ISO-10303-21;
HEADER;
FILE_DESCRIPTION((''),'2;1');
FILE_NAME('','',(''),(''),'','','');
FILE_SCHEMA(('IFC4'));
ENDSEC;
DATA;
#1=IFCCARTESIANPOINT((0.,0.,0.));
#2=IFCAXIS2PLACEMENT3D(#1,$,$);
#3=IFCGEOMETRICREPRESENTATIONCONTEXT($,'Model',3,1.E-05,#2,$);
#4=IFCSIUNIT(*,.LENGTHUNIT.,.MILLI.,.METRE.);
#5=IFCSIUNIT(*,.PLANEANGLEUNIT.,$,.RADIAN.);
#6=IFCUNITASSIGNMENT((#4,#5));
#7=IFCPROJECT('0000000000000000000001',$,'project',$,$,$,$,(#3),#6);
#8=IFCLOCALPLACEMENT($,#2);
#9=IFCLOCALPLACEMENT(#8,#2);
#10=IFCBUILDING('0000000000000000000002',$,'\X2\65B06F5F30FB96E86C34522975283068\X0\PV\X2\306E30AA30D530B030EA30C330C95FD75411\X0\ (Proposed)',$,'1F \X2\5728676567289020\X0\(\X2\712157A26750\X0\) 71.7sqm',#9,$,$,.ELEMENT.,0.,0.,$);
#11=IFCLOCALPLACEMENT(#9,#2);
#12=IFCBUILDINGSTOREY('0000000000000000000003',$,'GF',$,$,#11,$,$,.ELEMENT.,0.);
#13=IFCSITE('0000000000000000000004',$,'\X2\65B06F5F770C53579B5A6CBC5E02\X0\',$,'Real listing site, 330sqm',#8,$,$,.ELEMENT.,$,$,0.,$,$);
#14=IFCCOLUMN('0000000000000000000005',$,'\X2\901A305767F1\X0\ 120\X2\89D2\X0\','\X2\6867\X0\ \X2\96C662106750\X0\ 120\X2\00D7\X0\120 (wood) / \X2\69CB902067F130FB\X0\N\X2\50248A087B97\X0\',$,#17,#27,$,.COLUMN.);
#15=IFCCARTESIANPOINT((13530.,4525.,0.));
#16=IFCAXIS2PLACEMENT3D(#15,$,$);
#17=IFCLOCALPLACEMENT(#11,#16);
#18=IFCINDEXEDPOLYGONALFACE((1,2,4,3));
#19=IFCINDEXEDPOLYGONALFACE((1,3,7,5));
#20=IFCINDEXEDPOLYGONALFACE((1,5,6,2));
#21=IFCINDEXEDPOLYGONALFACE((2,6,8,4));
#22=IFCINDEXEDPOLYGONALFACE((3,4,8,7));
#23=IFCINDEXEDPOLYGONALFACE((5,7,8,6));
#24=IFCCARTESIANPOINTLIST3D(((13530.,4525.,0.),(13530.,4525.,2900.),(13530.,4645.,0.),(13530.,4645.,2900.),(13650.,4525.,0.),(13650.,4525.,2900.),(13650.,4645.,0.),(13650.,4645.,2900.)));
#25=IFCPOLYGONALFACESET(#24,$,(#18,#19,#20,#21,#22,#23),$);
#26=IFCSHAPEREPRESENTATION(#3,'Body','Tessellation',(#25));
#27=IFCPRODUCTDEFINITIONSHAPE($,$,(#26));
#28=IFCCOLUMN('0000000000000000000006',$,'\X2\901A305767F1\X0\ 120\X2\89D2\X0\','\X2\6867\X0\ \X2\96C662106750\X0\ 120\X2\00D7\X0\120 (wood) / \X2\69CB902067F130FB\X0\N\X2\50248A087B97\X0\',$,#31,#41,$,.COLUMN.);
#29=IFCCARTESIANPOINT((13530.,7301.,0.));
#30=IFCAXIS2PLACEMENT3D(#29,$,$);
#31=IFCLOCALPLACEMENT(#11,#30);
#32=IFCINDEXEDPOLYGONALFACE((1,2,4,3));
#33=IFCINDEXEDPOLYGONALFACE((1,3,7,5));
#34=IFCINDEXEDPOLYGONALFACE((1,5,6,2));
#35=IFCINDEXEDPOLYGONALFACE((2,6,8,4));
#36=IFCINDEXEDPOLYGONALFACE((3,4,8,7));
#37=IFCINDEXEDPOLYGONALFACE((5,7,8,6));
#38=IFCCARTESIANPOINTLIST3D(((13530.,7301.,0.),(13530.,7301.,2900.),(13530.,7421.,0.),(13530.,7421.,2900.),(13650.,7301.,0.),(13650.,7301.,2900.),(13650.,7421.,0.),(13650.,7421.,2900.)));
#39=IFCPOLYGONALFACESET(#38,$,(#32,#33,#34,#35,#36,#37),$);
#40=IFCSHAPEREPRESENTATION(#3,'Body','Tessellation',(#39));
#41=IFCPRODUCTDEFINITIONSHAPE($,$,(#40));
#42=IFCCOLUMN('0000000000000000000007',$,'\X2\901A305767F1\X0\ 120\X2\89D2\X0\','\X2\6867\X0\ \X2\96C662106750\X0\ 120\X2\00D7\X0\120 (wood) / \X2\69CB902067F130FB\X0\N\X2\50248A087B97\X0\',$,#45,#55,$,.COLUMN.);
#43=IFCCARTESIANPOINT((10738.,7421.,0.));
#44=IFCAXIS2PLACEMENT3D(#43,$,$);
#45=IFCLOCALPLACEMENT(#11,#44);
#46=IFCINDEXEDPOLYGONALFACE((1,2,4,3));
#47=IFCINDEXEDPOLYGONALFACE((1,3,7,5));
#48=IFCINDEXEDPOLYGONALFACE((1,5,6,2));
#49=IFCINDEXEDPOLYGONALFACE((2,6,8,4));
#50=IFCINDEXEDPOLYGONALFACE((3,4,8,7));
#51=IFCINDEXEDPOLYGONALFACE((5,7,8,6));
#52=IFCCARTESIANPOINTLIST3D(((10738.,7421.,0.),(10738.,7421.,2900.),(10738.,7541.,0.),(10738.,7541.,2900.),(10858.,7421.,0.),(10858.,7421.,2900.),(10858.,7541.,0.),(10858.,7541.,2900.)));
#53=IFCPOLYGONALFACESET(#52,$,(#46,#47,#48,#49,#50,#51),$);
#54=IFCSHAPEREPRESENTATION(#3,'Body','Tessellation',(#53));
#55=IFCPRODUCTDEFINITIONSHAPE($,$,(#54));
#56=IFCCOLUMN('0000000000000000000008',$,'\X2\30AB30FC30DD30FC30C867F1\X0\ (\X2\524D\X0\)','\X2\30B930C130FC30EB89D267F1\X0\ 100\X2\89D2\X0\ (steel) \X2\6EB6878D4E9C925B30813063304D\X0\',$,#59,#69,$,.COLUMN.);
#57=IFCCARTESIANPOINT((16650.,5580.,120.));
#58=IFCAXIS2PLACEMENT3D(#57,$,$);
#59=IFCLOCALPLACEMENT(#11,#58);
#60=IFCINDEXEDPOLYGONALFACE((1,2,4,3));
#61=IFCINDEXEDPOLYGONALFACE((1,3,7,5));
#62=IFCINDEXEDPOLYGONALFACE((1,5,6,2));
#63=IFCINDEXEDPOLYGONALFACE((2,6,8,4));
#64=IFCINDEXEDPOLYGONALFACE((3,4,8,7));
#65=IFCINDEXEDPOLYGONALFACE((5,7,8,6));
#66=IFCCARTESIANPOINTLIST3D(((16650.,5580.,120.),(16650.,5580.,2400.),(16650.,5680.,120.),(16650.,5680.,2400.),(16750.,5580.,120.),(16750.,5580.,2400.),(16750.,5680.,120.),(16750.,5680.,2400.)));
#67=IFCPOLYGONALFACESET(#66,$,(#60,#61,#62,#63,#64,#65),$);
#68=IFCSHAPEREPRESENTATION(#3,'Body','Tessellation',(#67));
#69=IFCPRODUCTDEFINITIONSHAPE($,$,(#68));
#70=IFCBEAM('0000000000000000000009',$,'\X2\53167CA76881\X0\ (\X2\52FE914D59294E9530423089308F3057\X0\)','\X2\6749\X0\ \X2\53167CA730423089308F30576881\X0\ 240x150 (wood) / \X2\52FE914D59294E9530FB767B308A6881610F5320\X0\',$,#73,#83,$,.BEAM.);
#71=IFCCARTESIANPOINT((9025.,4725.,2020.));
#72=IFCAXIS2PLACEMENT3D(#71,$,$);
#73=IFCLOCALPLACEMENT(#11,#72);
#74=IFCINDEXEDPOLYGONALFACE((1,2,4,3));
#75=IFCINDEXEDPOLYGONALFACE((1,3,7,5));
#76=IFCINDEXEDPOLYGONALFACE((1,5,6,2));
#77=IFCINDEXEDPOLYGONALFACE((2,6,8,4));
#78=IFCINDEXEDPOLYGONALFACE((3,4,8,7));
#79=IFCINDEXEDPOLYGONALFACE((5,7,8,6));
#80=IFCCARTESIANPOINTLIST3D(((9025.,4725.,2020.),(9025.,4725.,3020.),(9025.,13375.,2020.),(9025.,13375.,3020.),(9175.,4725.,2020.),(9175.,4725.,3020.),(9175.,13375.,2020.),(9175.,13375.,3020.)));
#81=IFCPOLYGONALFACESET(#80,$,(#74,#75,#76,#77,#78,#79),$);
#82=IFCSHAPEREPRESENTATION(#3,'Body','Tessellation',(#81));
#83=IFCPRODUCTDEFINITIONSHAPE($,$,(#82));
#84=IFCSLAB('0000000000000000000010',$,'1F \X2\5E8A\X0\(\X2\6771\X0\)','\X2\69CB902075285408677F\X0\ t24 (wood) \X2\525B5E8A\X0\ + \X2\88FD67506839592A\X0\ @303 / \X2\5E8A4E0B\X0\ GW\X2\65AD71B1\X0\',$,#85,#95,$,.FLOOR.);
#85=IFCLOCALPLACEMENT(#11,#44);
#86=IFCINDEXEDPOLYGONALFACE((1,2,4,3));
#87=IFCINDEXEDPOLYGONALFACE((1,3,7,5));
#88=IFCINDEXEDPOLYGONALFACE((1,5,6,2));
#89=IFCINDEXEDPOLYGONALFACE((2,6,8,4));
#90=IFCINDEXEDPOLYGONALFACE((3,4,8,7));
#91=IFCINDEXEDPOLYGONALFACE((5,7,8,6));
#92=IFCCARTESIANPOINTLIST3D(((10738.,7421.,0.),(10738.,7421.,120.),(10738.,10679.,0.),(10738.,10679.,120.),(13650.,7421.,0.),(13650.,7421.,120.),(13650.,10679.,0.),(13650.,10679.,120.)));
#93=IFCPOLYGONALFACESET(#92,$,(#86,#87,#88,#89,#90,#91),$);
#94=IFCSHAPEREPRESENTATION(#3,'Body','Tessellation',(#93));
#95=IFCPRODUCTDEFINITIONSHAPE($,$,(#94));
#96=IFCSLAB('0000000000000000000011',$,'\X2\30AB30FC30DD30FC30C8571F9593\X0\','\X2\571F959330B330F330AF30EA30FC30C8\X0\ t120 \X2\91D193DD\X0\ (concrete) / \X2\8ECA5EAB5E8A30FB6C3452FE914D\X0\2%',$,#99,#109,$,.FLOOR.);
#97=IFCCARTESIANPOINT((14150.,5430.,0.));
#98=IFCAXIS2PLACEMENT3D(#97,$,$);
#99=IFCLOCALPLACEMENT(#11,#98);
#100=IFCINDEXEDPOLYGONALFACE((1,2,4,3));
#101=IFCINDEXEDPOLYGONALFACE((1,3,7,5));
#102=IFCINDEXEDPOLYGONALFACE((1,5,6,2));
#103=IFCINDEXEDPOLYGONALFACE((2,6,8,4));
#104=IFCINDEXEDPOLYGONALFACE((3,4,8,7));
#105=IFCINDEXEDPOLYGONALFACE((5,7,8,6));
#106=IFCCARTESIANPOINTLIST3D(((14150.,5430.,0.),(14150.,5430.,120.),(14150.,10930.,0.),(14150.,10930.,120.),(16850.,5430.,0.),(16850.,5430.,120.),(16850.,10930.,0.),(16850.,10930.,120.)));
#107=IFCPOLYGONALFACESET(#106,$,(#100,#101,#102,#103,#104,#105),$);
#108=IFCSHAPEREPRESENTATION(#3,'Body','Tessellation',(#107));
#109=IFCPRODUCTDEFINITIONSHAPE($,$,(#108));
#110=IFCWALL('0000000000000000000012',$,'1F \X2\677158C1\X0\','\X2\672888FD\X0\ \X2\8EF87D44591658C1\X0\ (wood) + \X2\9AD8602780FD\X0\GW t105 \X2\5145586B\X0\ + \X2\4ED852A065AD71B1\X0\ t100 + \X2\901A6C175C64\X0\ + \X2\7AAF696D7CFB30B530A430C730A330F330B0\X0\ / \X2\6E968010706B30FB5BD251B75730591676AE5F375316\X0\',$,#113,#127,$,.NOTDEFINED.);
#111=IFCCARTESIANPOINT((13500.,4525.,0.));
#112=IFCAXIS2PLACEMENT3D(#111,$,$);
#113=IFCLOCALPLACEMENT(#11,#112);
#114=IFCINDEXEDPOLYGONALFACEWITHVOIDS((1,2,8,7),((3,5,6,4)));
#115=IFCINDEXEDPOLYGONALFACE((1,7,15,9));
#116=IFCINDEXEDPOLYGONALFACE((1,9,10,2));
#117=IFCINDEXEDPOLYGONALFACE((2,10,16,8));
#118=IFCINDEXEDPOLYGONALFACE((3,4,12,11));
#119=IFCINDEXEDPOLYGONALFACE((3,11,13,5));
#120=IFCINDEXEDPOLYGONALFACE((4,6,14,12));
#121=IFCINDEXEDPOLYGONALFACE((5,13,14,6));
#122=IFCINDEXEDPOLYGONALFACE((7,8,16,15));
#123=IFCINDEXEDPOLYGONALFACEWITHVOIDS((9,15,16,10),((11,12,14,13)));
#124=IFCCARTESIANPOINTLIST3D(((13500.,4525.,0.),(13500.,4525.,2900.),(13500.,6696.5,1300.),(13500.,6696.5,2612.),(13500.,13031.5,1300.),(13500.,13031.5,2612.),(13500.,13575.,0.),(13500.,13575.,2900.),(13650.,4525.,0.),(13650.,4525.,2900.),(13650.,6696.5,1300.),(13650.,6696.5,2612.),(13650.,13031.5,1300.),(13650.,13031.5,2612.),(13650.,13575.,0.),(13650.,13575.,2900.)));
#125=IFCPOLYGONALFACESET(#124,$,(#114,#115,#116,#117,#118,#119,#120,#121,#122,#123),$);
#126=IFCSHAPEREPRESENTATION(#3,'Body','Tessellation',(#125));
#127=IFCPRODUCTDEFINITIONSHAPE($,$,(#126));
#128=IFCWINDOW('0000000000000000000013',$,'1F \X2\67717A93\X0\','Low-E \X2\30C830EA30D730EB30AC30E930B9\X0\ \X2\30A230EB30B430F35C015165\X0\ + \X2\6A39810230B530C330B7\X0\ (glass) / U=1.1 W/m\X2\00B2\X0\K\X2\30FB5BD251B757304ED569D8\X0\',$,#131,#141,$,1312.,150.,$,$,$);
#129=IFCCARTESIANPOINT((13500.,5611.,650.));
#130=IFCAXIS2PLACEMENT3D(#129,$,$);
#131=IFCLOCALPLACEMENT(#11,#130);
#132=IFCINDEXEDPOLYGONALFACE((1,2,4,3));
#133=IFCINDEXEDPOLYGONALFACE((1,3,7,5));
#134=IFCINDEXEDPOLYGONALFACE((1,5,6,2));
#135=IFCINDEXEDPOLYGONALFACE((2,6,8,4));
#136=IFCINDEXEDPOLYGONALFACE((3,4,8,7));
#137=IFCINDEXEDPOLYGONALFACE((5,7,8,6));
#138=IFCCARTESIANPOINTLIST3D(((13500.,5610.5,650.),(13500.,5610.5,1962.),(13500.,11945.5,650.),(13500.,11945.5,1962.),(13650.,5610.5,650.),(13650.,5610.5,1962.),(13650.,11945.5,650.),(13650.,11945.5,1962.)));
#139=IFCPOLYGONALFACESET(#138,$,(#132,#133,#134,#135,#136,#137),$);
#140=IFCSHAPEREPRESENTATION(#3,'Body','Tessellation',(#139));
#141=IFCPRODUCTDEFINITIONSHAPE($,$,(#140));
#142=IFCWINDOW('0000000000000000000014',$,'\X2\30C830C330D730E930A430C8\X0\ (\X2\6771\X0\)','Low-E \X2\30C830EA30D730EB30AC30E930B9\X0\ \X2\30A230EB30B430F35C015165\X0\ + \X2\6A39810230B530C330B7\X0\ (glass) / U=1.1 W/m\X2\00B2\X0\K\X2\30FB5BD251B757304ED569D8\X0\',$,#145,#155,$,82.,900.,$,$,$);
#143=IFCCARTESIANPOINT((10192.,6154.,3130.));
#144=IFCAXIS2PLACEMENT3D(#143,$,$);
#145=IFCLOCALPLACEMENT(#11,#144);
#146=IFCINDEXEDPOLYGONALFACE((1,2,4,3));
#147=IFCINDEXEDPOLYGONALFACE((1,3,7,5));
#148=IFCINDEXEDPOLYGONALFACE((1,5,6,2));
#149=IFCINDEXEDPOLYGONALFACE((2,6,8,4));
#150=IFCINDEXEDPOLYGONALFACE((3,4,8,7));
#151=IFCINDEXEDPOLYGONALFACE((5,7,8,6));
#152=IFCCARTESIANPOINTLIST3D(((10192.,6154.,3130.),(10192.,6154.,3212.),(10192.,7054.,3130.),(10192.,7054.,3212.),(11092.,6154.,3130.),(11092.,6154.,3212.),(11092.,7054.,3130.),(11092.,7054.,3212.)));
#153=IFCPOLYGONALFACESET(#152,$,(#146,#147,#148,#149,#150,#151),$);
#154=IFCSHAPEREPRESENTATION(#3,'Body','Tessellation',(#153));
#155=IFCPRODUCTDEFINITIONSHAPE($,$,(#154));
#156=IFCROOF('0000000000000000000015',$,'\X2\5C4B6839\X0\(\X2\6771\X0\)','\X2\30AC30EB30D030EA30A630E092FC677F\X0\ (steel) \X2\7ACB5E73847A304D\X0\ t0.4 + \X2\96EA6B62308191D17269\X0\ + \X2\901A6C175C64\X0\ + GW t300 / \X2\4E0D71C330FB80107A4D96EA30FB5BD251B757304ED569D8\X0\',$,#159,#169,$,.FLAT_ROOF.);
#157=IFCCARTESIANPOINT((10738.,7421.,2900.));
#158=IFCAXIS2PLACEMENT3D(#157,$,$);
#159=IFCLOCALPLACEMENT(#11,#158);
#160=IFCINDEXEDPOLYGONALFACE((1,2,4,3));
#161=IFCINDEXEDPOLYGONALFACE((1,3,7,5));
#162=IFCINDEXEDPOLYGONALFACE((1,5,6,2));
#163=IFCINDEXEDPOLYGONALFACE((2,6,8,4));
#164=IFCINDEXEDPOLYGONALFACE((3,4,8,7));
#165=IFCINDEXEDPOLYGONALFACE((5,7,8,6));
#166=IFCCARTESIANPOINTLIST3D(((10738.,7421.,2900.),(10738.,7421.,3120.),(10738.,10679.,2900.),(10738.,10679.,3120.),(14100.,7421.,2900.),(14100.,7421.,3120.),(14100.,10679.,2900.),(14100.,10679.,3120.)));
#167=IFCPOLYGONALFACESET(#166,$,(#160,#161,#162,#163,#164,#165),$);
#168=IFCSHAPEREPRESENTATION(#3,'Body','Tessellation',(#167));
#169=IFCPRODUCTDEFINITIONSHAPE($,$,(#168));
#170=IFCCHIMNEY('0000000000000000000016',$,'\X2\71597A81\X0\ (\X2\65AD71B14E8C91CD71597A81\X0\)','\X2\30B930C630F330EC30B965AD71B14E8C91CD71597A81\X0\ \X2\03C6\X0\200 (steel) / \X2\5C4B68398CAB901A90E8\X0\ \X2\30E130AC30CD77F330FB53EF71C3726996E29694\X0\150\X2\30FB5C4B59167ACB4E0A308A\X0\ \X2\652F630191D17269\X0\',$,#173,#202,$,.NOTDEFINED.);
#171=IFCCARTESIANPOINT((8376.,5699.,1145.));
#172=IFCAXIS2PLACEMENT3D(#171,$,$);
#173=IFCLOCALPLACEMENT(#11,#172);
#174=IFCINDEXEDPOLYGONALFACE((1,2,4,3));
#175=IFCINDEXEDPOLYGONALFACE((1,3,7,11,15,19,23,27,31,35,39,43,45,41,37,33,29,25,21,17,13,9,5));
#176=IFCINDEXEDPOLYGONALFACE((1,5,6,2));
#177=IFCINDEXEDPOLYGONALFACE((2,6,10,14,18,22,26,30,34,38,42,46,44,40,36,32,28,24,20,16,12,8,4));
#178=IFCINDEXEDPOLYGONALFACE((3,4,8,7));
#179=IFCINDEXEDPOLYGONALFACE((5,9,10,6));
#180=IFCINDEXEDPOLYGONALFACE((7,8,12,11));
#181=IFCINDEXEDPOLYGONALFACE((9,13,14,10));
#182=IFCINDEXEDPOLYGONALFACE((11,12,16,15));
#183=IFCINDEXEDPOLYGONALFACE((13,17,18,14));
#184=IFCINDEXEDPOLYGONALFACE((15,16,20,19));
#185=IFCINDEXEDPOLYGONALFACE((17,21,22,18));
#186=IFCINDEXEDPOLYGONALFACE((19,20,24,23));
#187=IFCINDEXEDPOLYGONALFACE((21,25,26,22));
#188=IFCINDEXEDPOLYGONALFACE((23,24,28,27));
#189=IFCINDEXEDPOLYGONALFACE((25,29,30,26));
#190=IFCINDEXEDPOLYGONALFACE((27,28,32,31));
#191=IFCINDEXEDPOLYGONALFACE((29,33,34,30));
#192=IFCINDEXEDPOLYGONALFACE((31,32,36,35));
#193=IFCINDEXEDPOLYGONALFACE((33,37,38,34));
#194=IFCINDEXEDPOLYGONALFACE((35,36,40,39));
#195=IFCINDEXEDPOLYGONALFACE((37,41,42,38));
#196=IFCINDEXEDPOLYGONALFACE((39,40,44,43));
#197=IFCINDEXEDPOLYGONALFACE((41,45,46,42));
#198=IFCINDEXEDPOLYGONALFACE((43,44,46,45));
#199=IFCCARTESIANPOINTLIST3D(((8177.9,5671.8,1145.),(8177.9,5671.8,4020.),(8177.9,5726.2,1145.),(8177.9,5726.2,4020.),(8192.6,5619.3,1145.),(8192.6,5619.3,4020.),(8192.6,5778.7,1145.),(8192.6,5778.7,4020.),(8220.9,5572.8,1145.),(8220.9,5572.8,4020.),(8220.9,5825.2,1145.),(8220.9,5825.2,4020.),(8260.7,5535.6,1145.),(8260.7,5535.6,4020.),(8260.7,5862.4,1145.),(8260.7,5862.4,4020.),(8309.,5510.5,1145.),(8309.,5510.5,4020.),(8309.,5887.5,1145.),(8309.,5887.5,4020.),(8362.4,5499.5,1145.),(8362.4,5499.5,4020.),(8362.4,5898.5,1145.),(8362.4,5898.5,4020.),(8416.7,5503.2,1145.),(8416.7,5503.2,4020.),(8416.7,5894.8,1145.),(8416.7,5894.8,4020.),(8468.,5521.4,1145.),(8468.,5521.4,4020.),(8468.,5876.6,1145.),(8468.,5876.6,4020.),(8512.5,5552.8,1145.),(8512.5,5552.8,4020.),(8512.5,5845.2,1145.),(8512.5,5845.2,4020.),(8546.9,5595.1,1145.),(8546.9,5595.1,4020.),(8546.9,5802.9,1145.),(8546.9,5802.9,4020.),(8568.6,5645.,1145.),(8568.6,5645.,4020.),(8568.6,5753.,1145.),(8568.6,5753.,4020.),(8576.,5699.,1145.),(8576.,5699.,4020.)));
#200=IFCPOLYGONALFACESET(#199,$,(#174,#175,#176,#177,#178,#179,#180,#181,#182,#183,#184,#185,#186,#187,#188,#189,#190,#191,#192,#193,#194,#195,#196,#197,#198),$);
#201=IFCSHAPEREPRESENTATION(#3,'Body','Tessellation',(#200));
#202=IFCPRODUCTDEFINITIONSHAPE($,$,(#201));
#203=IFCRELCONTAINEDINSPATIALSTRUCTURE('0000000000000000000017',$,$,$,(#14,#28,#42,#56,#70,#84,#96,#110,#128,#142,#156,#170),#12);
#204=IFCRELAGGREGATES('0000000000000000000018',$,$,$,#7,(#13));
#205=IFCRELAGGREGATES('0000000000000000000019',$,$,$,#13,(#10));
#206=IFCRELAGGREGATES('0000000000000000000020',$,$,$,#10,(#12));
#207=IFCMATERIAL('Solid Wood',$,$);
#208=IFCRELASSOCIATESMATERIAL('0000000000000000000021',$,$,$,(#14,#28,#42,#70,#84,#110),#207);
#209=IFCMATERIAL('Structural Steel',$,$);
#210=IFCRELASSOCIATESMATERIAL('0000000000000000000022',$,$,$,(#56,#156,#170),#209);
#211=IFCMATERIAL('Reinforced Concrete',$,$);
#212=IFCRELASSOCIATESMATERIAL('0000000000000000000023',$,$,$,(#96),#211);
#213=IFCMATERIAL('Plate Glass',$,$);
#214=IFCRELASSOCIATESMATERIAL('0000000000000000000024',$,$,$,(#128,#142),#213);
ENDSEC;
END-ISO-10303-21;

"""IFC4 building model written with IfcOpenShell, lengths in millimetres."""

from ifc_helpers import new_model, si_unit, frame, frame_2d, origin, origin_2d, place, context, project, spatial, rectangle, circle, extrude, material, element, fill, save


model = new_model("IFC4")

# Units and contexts
model_context = context("Model", 3, precision=1e-05, world=origin())
ifc_project = project(units=[si_unit("LENGTHUNIT", "METRE", prefix="MILLI"), si_unit("PLANEANGLEUNIT", "RADIAN")], contexts=[model_context])

# Site, building, storey
site_placement = place(None, origin())
site = spatial("IfcSite", under=ifc_project, at=site_placement, Name="新潟県南魚沼市", ObjectType="Real listing site, 330sqm", CompositionType="ELEMENT", RefElevation=0.0)
building_placement = place(site_placement, origin())
building = spatial("IfcBuilding", under=site, at=building_placement, Name="新潟・雨水利用とPVのオフグリッド志向 (Proposed)", ObjectType="1F 在来木造(無垢材) 71.7sqm", CompositionType="ELEMENT", ElevationOfRefHeight=0.0, ElevationOfTerrain=0.0)
storey_placement = place(building_placement, origin())
storey = spatial("IfcBuildingStorey", under=building, at=storey_placement, Name="GF", CompositionType="ELEMENT", Elevation=0.0)

# Columns
ifc_material_1 = material(Name="Solid Wood")
column_1_placement = place(storey_placement, frame((13530.0, 4525.0, 0.0)))
element("IfcColumn", 1, at=column_1_placement, inside=storey, material=ifc_material_1, Name="通し柱 120角", Description="桧 集成材 120×120 (wood) / 構造柱・N値計算", PredefinedType="COLUMN", context=model_context, shape_type="SweptSolid", body=[
    extrude(rectangle(XDim=120.0, YDim=120.0, at=frame_2d((60.0, 60.0))), frame((13530.0, 4525.0, 0.0)), (0.0, 0.0, 1.0), 2900.0),
])
column_2_placement = place(storey_placement, frame((13530.0, 7301.0, 0.0)))
element("IfcColumn", 2, at=column_2_placement, inside=storey, material=ifc_material_1, Name="通し柱 120角", Description="桧 集成材 120×120 (wood) / 構造柱・N値計算", PredefinedType="COLUMN", context=model_context, shape_type="SweptSolid", body=[
    extrude(rectangle(XDim=120.0, YDim=120.0, at=frame_2d((60.0, 60.0))), frame((13530.0, 7301.0, 0.0)), (0.0, 0.0, 1.0), 2900.0),
])
column_3_placement = place(storey_placement, frame((10738.0, 7421.0, 0.0)))
element("IfcColumn", 3, at=column_3_placement, inside=storey, material=ifc_material_1, Name="通し柱 120角", Description="桧 集成材 120×120 (wood) / 構造柱・N値計算", PredefinedType="COLUMN", context=model_context, shape_type="SweptSolid", body=[
    extrude(rectangle(XDim=120.0, YDim=120.0, at=frame_2d((60.0, 60.0))), frame((10738.0, 7421.0, 0.0)), (0.0, 0.0, 1.0), 2900.0),
])
ifc_material_2 = material(Name="Structural Steel")
column_4_placement = place(storey_placement, frame((16650.0, 5580.0, 120.0)))
element("IfcColumn", 4, at=column_4_placement, inside=storey, material=ifc_material_2, Name="カーポート柱 (前)", Description="スチール角柱 100角 (steel) 溶融亜鉛めっき", PredefinedType="COLUMN", context=model_context, shape_type="SweptSolid", body=[
    extrude(rectangle(XDim=100.0, YDim=100.0, at=frame_2d((50.0, 50.0))), frame((16650.0, 5580.0, 120.0)), (0.0, 0.0, 1.0), 2280.0),
])

# Beam
beam_1_placement = place(storey_placement, frame((9025.0, 4725.0, 2020.0)))
element("IfcBeam", 5, at=beam_1_placement, inside=storey, material=ifc_material_1, Name="化粧梁 (勾配天井あらわし)", Description="杉 化粧あらわし梁 240x150 (wood) / 勾配天井・登り梁意匠", PredefinedType="BEAM", context=model_context, shape_type="SweptSolid", body=[
    extrude(rectangle(XDim=150.0, YDim=8650.0, at=frame_2d((75.0, 4325.0))), frame((9025.0, 4725.0, 2020.0)), (0.0, 0.0, 1.0), 1000.0),
])

# Slabs
slab_1_placement = place(storey_placement, frame((10738.0, 7421.0, 0.0)))
element("IfcSlab", 6, at=slab_1_placement, inside=storey, material=ifc_material_1, Name="1F 床(東)", Description="構造用合板 t24 (wood) 剛床 + 製材根太 @303 / 床下 GW断熱", PredefinedType="FLOOR", context=model_context, shape_type="SweptSolid", body=[
    extrude(rectangle(XDim=2912.0, YDim=3258.0, at=frame_2d((1456.0, 1629.0))), frame((10738.0, 7421.0, 0.0)), (0.0, 0.0, 1.0), 120.0),
])
ifc_material_3 = material(Name="Reinforced Concrete")
slab_2_placement = place(storey_placement, frame((14150.0, 5430.0, 0.0)))
element("IfcSlab", 7, at=slab_2_placement, inside=storey, material=ifc_material_3, Name="カーポート土間", Description="土間コンクリート t120 金鏝 (concrete) / 車庫床・水勾配2%", PredefinedType="FLOOR", context=model_context, shape_type="SweptSolid", body=[
    extrude(rectangle(XDim=2700.0, YDim=5500.0, at=frame_2d((1350.0, 2750.0))), frame((14150.0, 5430.0, 0.0)), (0.0, 0.0, 1.0), 120.0),
])

# Wall, opening, window
wall_1_placement = place(storey_placement, frame((13500.0, 4525.0, 0.0)))
wall_1 = element("IfcWall", 8, at=wall_1_placement, inside=storey, material=ifc_material_1, Name="1F 東壁", Description="木製 軸組外壁 (wood) + 高性能GW t105 充填 + 付加断熱 t100 + 通気層 + 窯業系サイディング / 準耐火・寒冷地外皮強化", PredefinedType="NOTDEFINED", context=model_context, shape_type="SweptSolid", body=[
    extrude(rectangle(XDim=150.0, YDim=9050.0, at=frame_2d((75.0, 4525.0))), frame((13500.0, 4525.0, 0.0)), (0.0, 0.0, 1.0), 2900.0),
])
opening_placement = place(storey_placement, frame((13500.0, 5611.0, 650.0)))
opening = element("IfcOpeningElement", 9, at=opening_placement, cuts=wall_1, PredefinedType="NOTDEFINED", context=model_context, shape_type="SweptSolid", body=[
    extrude(rectangle(XDim=150.0, YDim=6335.0, at=frame_2d((75.0, 3167.0))), frame((13500.0, 5611.0, 650.0)), (0.0, 0.0, 1.0), 1312.0),
])
ifc_material_4 = material(Name="Plate Glass")
window_1_placement = place(storey_placement, frame((13500.0, 5611.0, 650.0)))
window_1 = element("IfcWindow", 10, at=window_1_placement, inside=storey, material=ifc_material_4, Name="1F 東窓", Description="Low-E トリプルガラス アルゴン封入 + 樹脂サッシ (glass) / U=1.1 W/m²K・寒冷地仕様", OverallHeight=1312.0, OverallWidth=150.0, context=model_context, shape_type="SweptSolid", body=[
    extrude(rectangle(XDim=150.0, YDim=6335.0, at=frame_2d((75.0, 3167.0))), frame((13500.0, 5611.0, 650.0)), (0.0, 0.0, 1.0), 1312.0),
])
fill(opening, window_1)

# Window
window_2_placement = place(storey_placement, frame((10192.0, 6154.0, 3130.0)))
element("IfcWindow", 11, at=window_2_placement, inside=storey, material=ifc_material_4, Name="トップライト (東)", Description="Low-E トリプルガラス アルゴン封入 + 樹脂サッシ (glass) / U=1.1 W/m²K・寒冷地仕様", OverallHeight=82.0, OverallWidth=900.0, context=model_context, shape_type="SweptSolid", body=[
    extrude(rectangle(XDim=900.0, YDim=900.0, at=frame_2d((450.0, 450.0))), frame((10192.0, 6154.0, 3130.0)), (0.0, 0.0, 1.0), 82.0),
])

# Roof
roof_1_placement = place(storey_placement, frame((10738.0, 7421.0, 2900.0)))
element("IfcRoof", 12, at=roof_1_placement, inside=storey, material=ifc_material_2, Name="屋根(東)", Description="ガルバリウム鋼板 (steel) 立平葺き t0.4 + 雪止め金物 + 通気層 + GW t300 / 不燃・耐積雪・寒冷地仕様", PredefinedType="FLAT_ROOF", context=model_context, shape_type="SweptSolid", body=[
    extrude(rectangle(XDim=3362.0, YDim=3258.0, at=frame_2d((1681.0, 1629.0))), frame((10738.0, 7421.0, 2900.0)), (0.0, 0.0, 1.0), 220.0),
])

# Chimney
chimney_placement = place(storey_placement, frame((8376.0, 5699.0, 1145.0)))
element("IfcChimney", 13, at=chimney_placement, inside=storey, material=ifc_material_2, Name="煙突 (断熱二重煙突)", Description="ステンレス断熱二重煙突 φ200 (steel) / 屋根貫通部 メガネ石・可燃物離隔150・屋外立上り 支持金物", PredefinedType="NOTDEFINED", context=model_context, shape_type="SweptSolid", body=[
    extrude(circle(Radius=200.0, at=origin_2d()), frame((8376.0, 5699.0, 1145.0)), (0.0, 0.0, 1.0), 2875.0),
])

save(model, "model.ifc")
